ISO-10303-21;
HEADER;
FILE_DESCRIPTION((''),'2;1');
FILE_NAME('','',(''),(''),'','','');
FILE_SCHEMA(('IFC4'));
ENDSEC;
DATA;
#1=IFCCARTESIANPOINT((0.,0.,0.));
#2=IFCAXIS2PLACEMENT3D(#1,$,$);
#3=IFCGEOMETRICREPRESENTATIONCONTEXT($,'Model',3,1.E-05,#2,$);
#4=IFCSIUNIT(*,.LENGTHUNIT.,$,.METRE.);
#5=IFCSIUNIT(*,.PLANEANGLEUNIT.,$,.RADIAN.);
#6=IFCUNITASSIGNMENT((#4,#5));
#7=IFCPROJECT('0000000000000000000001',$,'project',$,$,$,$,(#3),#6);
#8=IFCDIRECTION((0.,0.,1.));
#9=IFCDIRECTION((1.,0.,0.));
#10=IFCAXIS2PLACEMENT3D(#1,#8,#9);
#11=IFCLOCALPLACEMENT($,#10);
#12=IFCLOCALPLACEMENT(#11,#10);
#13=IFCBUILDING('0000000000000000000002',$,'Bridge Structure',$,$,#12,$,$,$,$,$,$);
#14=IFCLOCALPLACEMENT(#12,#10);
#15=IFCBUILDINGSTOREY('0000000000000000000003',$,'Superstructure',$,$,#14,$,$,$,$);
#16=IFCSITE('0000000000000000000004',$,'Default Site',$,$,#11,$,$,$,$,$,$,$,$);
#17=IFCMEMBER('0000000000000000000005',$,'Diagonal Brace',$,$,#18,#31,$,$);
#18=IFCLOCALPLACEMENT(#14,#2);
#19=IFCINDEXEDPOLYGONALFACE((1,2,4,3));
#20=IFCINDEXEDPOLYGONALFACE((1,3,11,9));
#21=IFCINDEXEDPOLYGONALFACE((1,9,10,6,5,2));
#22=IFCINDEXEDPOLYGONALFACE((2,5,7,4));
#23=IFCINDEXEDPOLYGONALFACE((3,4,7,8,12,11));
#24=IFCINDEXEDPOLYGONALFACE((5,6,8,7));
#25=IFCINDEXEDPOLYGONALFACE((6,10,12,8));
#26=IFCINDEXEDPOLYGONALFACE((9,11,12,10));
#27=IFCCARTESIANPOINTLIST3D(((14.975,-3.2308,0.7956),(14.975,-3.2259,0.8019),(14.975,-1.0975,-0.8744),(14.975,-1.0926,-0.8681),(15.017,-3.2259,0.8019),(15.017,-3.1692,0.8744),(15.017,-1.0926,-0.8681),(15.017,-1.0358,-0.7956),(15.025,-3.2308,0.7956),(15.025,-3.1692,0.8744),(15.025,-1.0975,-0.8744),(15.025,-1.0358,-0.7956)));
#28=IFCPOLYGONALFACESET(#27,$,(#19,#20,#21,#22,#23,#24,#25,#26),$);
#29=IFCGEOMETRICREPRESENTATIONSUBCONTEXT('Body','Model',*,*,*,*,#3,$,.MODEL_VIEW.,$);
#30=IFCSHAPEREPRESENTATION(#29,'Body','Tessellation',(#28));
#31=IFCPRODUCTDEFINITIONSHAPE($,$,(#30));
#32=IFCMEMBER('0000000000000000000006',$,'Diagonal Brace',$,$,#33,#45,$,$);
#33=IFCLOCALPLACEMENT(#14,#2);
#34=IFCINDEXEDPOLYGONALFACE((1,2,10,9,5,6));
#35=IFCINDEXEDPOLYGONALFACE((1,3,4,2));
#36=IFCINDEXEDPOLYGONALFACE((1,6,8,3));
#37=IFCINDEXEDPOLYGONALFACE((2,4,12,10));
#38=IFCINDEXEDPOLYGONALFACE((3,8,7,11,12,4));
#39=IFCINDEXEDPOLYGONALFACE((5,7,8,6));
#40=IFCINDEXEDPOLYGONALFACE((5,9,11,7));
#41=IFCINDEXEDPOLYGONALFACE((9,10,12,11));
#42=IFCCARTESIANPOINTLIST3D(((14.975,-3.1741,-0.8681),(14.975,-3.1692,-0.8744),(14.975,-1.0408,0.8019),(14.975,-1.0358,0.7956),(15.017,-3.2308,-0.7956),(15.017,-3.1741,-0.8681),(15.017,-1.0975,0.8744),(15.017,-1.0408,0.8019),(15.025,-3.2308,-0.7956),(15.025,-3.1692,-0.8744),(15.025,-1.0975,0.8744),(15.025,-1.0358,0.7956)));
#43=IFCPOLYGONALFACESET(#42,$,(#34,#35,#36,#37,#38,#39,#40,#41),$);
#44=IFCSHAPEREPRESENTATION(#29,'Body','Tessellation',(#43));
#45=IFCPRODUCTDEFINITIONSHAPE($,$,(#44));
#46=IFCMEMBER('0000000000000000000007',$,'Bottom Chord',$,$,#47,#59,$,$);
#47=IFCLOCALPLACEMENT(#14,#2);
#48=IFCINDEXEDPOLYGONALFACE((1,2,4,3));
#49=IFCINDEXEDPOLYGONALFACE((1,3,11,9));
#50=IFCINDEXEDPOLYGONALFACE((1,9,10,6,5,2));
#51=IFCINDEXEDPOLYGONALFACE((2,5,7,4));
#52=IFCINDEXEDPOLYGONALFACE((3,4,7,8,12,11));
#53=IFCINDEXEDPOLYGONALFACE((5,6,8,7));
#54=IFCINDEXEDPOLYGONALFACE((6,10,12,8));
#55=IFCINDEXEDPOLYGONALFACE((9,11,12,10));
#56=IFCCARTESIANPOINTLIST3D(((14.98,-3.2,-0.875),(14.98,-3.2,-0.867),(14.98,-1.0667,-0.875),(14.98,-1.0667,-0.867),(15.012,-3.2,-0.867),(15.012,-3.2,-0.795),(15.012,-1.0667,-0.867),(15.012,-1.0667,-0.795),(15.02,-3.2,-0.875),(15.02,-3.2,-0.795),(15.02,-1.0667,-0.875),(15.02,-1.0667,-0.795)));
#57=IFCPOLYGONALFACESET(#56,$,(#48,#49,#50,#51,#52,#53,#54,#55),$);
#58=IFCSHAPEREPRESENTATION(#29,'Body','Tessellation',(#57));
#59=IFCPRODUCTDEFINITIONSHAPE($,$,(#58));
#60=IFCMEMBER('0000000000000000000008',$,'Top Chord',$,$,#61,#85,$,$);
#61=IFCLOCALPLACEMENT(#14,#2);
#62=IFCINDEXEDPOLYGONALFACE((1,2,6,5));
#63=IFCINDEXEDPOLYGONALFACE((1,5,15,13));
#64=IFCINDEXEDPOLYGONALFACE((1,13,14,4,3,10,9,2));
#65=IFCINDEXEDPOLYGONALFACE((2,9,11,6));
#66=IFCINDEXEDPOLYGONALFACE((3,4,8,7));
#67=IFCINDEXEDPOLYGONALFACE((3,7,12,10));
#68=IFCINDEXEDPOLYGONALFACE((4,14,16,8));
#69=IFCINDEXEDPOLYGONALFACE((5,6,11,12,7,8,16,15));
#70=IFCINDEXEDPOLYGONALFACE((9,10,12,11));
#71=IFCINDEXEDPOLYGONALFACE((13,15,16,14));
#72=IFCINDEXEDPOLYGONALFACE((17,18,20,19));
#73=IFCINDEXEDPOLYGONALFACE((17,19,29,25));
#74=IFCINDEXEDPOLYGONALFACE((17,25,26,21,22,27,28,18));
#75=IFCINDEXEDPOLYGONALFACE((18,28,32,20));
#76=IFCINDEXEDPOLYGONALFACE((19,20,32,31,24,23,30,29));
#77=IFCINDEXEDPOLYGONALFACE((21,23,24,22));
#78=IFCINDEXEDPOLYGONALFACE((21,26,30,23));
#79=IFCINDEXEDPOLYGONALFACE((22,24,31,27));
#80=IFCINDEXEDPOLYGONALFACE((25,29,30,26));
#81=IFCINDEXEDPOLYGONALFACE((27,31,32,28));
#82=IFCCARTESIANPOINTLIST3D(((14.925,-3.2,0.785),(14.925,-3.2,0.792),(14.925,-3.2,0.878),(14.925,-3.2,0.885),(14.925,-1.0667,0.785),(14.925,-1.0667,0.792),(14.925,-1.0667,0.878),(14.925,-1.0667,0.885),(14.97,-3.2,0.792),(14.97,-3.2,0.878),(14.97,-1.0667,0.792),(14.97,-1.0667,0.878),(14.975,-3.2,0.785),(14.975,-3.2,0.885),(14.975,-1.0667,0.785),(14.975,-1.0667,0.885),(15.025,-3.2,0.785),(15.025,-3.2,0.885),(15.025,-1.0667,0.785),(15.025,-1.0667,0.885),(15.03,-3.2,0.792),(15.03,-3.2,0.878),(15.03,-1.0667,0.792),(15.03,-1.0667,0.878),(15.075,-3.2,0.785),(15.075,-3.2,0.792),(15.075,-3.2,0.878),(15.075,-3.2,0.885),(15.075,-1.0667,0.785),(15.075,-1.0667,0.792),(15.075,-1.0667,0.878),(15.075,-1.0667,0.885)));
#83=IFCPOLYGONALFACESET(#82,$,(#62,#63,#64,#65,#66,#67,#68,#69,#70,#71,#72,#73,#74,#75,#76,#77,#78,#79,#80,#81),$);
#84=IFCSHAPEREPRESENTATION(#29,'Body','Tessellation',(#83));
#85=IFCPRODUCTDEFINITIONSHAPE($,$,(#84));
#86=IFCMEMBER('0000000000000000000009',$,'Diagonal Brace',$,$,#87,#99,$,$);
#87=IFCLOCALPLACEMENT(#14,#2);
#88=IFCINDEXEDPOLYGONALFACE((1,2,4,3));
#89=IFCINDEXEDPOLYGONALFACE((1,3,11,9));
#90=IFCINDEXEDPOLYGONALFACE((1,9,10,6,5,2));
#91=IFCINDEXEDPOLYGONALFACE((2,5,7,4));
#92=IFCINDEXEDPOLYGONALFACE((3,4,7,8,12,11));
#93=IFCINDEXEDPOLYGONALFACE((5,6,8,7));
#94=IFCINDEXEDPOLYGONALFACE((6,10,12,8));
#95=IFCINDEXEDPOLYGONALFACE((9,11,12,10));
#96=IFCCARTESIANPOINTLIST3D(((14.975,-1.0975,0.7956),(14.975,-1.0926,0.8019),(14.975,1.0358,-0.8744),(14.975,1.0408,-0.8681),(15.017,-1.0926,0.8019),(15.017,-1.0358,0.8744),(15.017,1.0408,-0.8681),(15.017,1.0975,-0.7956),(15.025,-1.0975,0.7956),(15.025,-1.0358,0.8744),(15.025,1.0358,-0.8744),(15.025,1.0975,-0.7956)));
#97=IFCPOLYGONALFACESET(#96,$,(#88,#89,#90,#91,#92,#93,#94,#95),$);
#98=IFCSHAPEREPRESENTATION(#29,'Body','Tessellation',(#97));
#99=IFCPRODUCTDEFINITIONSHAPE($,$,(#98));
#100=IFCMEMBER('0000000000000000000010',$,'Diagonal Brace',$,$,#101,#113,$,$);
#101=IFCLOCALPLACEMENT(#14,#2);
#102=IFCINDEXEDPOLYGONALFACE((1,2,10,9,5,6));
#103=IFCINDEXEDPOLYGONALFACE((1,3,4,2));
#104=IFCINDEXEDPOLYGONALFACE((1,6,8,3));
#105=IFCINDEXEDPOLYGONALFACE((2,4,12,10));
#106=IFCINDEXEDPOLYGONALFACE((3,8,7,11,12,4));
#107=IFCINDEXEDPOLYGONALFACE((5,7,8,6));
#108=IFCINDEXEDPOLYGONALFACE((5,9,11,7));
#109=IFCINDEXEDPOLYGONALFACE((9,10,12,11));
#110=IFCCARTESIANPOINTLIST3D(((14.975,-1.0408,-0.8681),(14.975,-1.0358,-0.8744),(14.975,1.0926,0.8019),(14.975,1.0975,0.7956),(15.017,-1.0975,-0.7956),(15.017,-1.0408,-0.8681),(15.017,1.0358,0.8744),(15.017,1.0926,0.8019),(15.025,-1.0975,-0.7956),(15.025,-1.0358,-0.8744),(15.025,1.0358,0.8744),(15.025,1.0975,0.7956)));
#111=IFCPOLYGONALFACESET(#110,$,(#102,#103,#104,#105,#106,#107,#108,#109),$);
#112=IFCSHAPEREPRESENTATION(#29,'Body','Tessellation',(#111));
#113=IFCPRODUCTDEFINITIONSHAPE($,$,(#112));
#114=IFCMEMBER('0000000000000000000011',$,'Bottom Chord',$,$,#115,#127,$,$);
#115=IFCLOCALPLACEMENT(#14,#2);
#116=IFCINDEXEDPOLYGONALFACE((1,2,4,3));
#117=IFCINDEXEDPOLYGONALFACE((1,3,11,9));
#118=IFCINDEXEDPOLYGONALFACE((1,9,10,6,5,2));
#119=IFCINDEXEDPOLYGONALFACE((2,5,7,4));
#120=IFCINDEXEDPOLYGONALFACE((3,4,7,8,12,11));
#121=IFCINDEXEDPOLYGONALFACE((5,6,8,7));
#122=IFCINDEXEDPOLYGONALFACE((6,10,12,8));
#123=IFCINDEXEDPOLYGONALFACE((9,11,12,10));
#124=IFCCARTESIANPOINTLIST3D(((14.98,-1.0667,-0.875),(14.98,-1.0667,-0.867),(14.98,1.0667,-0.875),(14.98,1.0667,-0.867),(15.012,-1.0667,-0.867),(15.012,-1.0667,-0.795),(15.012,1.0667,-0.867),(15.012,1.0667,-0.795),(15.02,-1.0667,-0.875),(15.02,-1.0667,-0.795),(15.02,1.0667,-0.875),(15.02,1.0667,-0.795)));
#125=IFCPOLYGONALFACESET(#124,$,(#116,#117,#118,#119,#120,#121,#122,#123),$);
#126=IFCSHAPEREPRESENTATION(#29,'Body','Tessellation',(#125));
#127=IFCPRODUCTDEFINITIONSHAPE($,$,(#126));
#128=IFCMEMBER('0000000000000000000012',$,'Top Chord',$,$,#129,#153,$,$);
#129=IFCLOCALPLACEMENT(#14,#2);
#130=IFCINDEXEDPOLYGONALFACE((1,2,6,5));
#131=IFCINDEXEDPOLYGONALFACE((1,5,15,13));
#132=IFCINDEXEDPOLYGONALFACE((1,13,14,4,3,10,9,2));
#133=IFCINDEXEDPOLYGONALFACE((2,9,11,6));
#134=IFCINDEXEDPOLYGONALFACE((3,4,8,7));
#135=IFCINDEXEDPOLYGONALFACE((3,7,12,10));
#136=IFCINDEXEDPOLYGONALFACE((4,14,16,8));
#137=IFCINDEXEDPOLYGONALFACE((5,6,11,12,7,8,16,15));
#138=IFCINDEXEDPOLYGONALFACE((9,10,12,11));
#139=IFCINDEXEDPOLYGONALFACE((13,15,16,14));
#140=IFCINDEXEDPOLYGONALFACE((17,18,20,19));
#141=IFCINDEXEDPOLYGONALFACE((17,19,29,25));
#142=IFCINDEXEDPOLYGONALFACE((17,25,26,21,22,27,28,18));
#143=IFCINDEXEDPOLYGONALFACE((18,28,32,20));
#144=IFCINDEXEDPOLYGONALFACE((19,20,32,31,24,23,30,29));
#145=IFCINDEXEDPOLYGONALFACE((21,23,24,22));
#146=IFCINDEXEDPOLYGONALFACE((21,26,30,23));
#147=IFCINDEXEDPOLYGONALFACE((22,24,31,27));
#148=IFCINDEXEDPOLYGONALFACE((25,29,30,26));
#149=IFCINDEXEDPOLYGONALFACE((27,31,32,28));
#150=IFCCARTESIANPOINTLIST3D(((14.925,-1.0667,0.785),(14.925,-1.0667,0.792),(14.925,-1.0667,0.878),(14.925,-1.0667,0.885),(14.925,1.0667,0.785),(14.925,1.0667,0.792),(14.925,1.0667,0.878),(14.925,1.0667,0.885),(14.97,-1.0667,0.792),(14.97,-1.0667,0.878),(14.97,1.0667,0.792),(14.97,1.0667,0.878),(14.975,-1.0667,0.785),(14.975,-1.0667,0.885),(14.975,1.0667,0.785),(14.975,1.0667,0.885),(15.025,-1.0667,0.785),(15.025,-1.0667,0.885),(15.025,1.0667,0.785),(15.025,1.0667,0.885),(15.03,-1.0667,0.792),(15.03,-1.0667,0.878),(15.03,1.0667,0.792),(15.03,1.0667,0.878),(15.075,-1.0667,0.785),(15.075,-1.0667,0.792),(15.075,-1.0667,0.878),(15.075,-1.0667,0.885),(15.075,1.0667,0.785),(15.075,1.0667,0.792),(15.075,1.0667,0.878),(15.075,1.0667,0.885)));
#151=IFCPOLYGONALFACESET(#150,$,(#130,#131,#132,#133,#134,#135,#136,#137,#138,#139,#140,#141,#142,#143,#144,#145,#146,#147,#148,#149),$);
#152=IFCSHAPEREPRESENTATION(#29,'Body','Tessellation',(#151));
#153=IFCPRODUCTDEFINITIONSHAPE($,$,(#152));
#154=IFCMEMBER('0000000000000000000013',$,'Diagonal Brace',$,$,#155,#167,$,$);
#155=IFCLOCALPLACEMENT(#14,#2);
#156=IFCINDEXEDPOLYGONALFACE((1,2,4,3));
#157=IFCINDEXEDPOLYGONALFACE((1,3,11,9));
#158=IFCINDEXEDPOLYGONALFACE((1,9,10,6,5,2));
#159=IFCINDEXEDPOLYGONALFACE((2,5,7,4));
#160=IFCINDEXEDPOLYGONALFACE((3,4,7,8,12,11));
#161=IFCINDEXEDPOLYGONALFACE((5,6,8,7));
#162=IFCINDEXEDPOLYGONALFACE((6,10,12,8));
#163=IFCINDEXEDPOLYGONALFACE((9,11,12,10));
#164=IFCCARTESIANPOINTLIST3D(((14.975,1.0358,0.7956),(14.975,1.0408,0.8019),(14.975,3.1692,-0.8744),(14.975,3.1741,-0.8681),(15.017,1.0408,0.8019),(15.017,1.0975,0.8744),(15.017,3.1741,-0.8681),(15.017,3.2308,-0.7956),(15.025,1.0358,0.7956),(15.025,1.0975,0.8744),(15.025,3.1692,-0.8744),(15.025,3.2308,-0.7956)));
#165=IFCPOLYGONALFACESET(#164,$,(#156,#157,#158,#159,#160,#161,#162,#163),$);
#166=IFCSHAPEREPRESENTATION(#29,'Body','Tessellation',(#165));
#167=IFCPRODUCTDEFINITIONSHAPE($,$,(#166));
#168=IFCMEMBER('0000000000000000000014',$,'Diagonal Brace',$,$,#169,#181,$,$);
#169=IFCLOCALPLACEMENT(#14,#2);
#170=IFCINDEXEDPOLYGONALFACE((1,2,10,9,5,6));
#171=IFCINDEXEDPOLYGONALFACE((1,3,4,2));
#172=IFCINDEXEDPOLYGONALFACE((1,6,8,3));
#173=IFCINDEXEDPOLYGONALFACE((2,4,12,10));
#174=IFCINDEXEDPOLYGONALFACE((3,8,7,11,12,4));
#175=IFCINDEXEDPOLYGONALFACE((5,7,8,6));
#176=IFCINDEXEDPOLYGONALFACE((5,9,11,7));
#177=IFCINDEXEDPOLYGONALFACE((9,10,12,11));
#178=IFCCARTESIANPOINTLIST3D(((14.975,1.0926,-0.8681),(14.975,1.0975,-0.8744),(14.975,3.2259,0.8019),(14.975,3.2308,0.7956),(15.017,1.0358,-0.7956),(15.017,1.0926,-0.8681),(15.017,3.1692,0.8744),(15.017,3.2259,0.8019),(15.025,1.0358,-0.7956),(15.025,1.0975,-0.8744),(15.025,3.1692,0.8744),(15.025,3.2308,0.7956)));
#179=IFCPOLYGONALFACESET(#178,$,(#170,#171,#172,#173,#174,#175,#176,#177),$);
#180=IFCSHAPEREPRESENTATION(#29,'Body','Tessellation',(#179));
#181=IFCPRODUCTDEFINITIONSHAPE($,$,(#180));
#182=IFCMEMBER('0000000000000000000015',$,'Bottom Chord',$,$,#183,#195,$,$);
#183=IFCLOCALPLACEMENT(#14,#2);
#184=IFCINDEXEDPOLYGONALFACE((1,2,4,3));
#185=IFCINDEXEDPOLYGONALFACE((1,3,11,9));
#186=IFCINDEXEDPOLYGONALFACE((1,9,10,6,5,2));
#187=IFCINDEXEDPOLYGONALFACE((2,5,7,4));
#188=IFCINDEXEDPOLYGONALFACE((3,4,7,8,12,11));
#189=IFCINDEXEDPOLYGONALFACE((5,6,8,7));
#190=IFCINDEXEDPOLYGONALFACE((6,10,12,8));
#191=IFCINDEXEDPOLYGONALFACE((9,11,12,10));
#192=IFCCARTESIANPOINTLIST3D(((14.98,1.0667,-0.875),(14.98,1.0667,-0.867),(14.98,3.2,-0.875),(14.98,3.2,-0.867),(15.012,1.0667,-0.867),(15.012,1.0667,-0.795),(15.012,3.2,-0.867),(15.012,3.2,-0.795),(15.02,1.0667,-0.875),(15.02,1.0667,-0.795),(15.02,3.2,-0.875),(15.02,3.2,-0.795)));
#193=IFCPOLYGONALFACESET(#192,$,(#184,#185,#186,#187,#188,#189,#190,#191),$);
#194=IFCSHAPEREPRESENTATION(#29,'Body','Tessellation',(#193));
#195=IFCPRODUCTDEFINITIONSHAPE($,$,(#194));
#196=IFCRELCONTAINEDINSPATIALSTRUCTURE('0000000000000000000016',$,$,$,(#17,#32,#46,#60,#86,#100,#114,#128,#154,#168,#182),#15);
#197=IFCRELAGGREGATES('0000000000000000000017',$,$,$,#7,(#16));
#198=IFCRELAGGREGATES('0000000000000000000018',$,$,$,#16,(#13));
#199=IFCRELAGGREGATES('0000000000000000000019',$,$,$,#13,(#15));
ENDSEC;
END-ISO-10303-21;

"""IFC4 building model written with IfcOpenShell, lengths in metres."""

from ifc_helpers import new_model, si_unit, frame, origin, origin_with_axes, origin_2d_with_axis, place, context, subcontext, project, spatial, polyline, l_section, outline, composite_profile, extrude, element, save


model = new_model("IFC4")

# Units and contexts
model_context = context("Model", 3, precision=1e-05, world=origin())
body_context = subcontext(model_context, "Body", "Model", "MODEL_VIEW")
ifc_project = project(units=[si_unit("LENGTHUNIT", "METRE"), si_unit("PLANEANGLEUNIT", "RADIAN")], contexts=[model_context])

# Site, building, storey
site_placement = place(None, origin_with_axes())
site = spatial("IfcSite", under=ifc_project, at=site_placement, Name="Default Site")
building_placement = place(site_placement, origin_with_axes())
building = spatial("IfcBuilding", under=site, at=building_placement, Name="Bridge Structure")
storey_placement = place(building_placement, origin_with_axes())
storey = spatial("IfcBuildingStorey", under=building, at=storey_placement, Name="Superstructure")

# Members
for number, where, z_axis, x_axis, name in (
    (1, (15.0, -3.2, 0.835), (0.0, 0.787427, -0.616408), (-1.0, 0.0, 0.0), "Diagonal Brace"),
    (2, (15.0, -3.2, -0.835), (0.0, 0.787427, 0.616408), (-1.0, 0.0, 0.0), "Diagonal Brace"),
):
    element("IfcMember", number, at=place(storey_placement, frame(where, z_axis=z_axis, x_axis=x_axis)), inside=storey, Name=name, context=body_context, shape_type="SweptSolid", body=[
        extrude(l_section(Depth=0.1, Width=0.05, Thickness=0.008, at=origin_2d_with_axis()), origin_with_axes(), (0.0, 0.0, 1.0), 2.7092),
    ])
member_1_placement = place(storey_placement, frame((15.0, -3.2, -0.835), z_axis=(0.0, 1.0, 0.0), x_axis=(-1.0, 0.0, 0.0)))
element("IfcMember", 3, at=member_1_placement, inside=storey, Name="Bottom Chord", context=body_context, shape_type="SweptSolid", body=[
    extrude(l_section(Depth=0.08, Width=0.04, Thickness=0.008, at=origin_2d_with_axis()), origin_with_axes(), (0.0, 0.0, 1.0), 2.1333),
])
member_2_placement = place(storey_placement, frame((15.0, -3.2, 0.835), z_axis=(0.0, 1.0, 0.0), x_axis=(-1.0, 0.0, 0.0)))
element("IfcMember", 4, at=member_2_placement, inside=storey, Name="Top Chord", context=body_context, shape_type="SweptSolid", body=[
    extrude(composite_profile([outline(polyline([(-0.025, -0.05), (-0.025, 0.05), (-0.075, 0.05), (-0.075, 0.043), (-0.03, 0.043), (-0.03, -0.043), (-0.075, -0.043), (-0.075, -0.05), (-0.025, -0.05)])), outline(polyline([(0.025, -0.05), (0.075, -0.05), (0.075, -0.043), (0.03, -0.043), (0.03, 0.043), (0.075, 0.043), (0.075, 0.05), (0.025, 0.05), (0.025, -0.05)]))]), origin_with_axes(), (0.0, 0.0, 1.0), 2.1333),
])
for number, where, z_axis, x_axis, name in (
    (5, (15.0, -1.0667, 0.835), (0.0, 0.787427, -0.616408), (-1.0, 0.0, 0.0), "Diagonal Brace"),
    (6, (15.0, -1.0667, -0.835), (0.0, 0.787427, 0.616408), (-1.0, 0.0, 0.0), "Diagonal Brace"),
):
    element("IfcMember", number, at=place(storey_placement, frame(where, z_axis=z_axis, x_axis=x_axis)), inside=storey, Name=name, context=body_context, shape_type="SweptSolid", body=[
        extrude(l_section(Depth=0.1, Width=0.05, Thickness=0.008, at=origin_2d_with_axis()), origin_with_axes(), (0.0, 0.0, 1.0), 2.7092),
    ])
member_3_placement = place(storey_placement, frame((15.0, -1.0667, -0.835), z_axis=(0.0, 1.0, 0.0), x_axis=(-1.0, 0.0, 0.0)))
element("IfcMember", 7, at=member_3_placement, inside=storey, Name="Bottom Chord", context=body_context, shape_type="SweptSolid", body=[
    extrude(l_section(Depth=0.08, Width=0.04, Thickness=0.008, at=origin_2d_with_axis()), origin_with_axes(), (0.0, 0.0, 1.0), 2.1333),
])
member_4_placement = place(storey_placement, frame((15.0, -1.0667, 0.835), z_axis=(0.0, 1.0, 0.0), x_axis=(-1.0, 0.0, 0.0)))
element("IfcMember", 8, at=member_4_placement, inside=storey, Name="Top Chord", context=body_context, shape_type="SweptSolid", body=[
    extrude(composite_profile([outline(polyline([(-0.025, -0.05), (-0.025, 0.05), (-0.075, 0.05), (-0.075, 0.043), (-0.03, 0.043), (-0.03, -0.043), (-0.075, -0.043), (-0.075, -0.05), (-0.025, -0.05)])), outline(polyline([(0.025, -0.05), (0.075, -0.05), (0.075, -0.043), (0.03, -0.043), (0.03, 0.043), (0.075, 0.043), (0.075, 0.05), (0.025, 0.05), (0.025, -0.05)]))]), origin_with_axes(), (0.0, 0.0, 1.0), 2.1333),
])
for number, where, z_axis, x_axis, name in (
    (9, (15.0, 1.0667, 0.835), (0.0, 0.787427, -0.616408), (-1.0, 0.0, 0.0), "Diagonal Brace"),
    (10, (15.0, 1.0667, -0.835), (0.0, 0.787427, 0.616408), (-1.0, 0.0, 0.0), "Diagonal Brace"),
):
    element("IfcMember", number, at=place(storey_placement, frame(where, z_axis=z_axis, x_axis=x_axis)), inside=storey, Name=name, context=body_context, shape_type="SweptSolid", body=[
        extrude(l_section(Depth=0.1, Width=0.05, Thickness=0.008, at=origin_2d_with_axis()), origin_with_axes(), (0.0, 0.0, 1.0), 2.7092),
    ])
member_5_placement = place(storey_placement, frame((15.0, 1.0667, -0.835), z_axis=(0.0, 1.0, 0.0), x_axis=(-1.0, 0.0, 0.0)))
element("IfcMember", 11, at=member_5_placement, inside=storey, Name="Bottom Chord", context=body_context, shape_type="SweptSolid", body=[
    extrude(l_section(Depth=0.08, Width=0.04, Thickness=0.008, at=origin_2d_with_axis()), origin_with_axes(), (0.0, 0.0, 1.0), 2.1333),
])

save(model, "model.ifc")
